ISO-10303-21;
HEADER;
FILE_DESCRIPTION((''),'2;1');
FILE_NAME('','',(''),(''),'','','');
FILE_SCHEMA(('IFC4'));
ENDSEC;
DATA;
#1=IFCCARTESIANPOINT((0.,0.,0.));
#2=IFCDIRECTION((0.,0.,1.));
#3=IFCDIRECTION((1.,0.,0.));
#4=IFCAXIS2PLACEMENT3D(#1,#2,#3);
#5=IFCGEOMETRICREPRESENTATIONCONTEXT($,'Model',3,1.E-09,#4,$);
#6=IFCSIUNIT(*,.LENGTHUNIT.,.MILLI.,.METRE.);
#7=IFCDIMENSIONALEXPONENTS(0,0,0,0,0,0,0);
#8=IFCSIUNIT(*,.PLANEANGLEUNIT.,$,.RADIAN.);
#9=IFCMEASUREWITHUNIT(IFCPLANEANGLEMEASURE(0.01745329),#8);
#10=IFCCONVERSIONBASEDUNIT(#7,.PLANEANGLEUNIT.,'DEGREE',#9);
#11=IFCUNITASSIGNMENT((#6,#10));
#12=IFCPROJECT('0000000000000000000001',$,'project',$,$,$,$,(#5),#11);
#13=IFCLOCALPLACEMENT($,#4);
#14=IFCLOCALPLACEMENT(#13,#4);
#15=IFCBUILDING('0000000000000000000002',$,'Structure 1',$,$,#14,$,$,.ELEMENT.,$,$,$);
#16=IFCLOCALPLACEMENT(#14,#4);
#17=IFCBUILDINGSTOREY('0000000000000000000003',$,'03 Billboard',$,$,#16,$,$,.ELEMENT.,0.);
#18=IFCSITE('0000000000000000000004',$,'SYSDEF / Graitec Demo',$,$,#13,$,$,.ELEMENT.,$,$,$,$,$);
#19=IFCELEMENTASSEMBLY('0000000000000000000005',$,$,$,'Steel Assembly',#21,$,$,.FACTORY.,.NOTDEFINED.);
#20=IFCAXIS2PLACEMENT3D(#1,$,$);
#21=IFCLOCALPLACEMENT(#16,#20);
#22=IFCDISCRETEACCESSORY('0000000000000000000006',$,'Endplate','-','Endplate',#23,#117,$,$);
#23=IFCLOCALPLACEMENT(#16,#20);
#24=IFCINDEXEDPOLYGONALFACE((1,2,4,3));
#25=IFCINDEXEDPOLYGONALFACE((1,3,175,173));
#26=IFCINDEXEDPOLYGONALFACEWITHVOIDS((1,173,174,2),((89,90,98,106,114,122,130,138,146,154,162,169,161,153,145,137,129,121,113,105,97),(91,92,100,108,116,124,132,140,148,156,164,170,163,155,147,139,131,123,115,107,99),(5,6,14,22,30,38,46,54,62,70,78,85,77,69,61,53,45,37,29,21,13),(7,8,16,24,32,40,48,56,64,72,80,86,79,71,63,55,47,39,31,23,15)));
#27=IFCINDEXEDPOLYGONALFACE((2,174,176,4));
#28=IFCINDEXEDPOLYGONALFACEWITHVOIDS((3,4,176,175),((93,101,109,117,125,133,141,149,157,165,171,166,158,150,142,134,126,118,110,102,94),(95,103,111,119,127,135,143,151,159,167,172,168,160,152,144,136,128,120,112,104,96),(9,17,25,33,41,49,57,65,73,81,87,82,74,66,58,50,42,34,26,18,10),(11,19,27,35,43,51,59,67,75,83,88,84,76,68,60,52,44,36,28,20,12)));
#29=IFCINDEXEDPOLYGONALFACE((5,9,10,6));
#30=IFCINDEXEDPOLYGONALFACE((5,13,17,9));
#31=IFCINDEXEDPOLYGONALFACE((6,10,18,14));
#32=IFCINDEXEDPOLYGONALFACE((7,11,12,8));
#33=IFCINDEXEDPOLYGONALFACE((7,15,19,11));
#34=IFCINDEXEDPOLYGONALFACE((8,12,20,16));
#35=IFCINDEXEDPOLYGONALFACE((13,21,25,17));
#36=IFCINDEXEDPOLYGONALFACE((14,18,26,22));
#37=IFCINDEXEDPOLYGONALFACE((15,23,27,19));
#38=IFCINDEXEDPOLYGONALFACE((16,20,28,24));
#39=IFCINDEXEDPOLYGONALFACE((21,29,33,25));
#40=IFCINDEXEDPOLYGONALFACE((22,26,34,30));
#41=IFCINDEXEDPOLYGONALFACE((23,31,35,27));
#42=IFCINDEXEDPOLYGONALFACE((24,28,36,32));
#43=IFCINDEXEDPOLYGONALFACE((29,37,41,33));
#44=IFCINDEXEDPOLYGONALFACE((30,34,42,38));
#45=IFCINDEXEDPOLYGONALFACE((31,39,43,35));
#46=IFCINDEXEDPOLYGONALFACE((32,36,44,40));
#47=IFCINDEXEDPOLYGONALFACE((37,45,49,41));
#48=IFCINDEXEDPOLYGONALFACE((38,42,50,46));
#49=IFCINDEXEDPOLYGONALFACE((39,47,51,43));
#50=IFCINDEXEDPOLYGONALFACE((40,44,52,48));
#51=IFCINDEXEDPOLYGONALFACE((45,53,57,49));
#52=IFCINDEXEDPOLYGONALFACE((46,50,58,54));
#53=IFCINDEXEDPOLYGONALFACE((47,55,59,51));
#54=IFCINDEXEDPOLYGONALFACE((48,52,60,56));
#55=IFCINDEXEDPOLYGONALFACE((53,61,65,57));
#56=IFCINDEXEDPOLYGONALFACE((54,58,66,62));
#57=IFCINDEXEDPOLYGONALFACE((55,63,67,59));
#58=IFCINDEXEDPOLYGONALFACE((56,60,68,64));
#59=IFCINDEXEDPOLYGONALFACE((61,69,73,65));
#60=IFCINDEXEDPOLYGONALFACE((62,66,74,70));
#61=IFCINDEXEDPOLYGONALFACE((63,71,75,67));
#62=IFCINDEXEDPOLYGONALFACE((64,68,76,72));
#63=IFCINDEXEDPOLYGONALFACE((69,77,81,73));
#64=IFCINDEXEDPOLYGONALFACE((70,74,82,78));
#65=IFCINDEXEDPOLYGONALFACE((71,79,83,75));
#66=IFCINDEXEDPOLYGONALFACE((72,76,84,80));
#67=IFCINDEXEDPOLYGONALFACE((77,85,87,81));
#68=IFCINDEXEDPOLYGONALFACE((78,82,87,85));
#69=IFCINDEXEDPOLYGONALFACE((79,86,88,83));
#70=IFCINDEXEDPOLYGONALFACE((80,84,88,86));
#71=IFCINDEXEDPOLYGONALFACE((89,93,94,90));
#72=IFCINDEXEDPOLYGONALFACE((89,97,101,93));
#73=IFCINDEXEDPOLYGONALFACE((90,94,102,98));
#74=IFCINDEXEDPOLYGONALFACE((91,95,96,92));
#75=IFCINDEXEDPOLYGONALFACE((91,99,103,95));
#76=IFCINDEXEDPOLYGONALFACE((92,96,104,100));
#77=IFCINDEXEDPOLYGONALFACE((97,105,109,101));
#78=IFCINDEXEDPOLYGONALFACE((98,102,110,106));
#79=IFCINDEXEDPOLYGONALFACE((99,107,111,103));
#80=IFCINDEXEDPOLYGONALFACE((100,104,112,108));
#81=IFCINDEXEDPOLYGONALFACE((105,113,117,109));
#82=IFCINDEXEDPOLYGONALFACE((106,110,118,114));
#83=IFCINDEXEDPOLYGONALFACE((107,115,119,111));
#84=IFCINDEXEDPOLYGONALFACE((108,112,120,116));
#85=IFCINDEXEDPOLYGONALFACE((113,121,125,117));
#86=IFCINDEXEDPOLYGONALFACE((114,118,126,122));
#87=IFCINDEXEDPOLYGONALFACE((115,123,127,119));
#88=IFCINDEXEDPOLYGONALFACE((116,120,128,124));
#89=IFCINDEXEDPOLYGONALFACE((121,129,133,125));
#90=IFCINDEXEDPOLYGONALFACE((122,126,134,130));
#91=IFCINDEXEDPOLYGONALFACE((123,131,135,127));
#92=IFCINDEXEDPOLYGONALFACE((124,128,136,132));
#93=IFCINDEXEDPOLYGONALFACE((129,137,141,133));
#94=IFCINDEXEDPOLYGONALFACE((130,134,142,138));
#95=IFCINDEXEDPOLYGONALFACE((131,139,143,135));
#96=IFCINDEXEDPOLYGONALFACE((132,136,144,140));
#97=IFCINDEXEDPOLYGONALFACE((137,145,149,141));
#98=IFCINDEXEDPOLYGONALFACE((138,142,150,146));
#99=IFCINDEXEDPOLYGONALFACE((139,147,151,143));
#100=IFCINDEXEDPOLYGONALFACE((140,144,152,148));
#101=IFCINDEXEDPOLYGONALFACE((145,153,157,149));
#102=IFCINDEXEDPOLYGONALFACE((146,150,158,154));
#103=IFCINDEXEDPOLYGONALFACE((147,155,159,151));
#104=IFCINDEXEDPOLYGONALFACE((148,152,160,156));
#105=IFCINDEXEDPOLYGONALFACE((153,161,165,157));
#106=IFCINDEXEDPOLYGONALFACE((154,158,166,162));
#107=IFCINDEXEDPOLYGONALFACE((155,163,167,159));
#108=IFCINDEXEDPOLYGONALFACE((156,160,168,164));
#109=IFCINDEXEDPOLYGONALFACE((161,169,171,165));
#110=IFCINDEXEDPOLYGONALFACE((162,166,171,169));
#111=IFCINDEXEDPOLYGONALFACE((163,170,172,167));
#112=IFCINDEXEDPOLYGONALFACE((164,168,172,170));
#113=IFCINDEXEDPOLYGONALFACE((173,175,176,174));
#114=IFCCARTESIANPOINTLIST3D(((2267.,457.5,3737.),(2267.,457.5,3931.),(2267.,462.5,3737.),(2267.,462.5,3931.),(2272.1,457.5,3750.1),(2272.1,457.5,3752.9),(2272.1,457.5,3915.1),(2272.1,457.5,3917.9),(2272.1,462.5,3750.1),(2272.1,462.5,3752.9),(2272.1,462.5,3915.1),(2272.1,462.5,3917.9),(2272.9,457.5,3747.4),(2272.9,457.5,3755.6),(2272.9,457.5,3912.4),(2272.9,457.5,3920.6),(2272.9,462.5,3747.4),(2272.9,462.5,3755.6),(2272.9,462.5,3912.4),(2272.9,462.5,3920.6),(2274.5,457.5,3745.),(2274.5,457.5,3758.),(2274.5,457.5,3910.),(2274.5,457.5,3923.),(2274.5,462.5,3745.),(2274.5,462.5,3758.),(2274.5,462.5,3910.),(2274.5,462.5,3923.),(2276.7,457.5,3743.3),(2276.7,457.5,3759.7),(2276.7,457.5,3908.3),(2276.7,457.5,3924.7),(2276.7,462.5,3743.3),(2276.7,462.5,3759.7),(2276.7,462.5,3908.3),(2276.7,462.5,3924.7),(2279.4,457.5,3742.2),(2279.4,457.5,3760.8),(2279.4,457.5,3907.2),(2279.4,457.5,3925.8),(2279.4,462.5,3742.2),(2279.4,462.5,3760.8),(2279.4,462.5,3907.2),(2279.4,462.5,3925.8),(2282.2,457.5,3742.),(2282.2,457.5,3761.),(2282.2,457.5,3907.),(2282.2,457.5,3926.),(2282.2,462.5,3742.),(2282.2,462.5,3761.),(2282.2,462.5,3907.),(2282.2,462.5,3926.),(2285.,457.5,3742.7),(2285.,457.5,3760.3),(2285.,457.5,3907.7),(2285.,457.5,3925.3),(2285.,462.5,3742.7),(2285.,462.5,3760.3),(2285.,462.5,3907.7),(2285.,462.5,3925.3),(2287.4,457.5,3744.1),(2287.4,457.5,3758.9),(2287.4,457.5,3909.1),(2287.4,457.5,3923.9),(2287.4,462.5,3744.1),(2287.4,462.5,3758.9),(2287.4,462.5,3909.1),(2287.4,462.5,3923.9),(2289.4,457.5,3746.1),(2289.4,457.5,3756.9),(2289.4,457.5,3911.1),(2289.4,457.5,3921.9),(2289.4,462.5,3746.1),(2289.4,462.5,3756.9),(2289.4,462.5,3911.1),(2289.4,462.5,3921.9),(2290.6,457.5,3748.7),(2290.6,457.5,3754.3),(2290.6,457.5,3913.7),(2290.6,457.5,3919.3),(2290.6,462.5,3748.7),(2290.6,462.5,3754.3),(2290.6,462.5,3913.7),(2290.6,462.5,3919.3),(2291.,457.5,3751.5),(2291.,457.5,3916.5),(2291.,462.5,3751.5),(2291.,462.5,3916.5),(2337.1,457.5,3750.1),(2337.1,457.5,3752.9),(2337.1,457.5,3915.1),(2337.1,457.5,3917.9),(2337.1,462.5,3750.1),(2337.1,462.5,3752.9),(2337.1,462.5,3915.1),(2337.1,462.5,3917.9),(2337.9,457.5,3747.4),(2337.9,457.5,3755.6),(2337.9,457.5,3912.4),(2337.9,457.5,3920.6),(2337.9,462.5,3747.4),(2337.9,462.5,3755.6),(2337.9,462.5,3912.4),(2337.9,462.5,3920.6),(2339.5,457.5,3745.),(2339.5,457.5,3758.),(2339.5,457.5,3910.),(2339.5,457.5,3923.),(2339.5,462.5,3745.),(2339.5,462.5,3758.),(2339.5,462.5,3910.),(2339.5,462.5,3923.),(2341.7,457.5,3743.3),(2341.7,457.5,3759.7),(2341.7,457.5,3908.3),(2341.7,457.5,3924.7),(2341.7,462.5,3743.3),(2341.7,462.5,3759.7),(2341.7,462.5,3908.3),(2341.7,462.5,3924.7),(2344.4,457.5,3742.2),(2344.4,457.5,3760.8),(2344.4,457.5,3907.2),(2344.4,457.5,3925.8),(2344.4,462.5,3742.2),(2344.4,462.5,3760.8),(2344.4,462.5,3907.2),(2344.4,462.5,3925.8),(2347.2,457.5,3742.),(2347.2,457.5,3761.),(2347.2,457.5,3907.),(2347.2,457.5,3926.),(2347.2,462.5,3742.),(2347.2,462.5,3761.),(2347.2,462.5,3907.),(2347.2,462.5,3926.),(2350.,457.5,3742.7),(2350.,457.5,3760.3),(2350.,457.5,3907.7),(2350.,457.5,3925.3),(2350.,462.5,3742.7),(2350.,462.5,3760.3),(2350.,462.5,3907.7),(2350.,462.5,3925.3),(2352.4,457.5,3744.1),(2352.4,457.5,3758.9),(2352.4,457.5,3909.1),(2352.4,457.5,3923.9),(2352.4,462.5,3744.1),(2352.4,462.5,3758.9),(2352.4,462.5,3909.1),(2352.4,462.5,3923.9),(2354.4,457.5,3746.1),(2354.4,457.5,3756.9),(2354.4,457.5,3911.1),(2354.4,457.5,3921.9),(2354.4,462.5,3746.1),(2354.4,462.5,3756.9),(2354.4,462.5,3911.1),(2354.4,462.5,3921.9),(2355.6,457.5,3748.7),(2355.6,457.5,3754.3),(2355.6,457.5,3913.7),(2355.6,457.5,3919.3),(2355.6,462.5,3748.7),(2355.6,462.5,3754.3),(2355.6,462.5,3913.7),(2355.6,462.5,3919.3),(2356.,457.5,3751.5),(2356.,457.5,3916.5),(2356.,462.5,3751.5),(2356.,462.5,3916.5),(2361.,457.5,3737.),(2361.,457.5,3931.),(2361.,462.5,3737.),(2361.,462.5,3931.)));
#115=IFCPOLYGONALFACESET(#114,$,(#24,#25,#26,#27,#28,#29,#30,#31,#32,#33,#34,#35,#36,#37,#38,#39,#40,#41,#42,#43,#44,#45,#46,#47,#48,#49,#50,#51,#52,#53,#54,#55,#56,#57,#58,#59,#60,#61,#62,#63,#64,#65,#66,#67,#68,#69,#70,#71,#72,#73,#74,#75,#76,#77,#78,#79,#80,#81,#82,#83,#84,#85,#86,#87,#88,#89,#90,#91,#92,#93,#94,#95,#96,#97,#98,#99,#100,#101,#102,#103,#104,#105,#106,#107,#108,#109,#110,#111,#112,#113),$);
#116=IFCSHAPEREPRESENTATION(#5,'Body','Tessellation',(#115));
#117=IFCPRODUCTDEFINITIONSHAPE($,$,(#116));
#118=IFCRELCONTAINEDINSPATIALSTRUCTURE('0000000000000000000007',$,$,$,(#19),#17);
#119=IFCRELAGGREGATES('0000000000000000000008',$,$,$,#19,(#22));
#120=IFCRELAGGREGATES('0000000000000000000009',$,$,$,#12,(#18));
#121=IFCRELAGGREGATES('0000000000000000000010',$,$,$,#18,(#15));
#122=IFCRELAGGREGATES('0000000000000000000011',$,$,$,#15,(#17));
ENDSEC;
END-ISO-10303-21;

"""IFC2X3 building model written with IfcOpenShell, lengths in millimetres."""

from ifc_helpers import new_model, entity, si_unit, converted_unit, frame, frame_2d, origin, origin_with_axes, place, context, project, spatial, polyline, circle, outline, extrude, element, aggregate, save


model = new_model("IFC2X3")

# Units and contexts
model_context = context("Model", 3, precision=1e-09, world=origin_with_axes())
ifc_project = project(units=[si_unit("LENGTHUNIT", "METRE", prefix="MILLI"), converted_unit("PLANEANGLEUNIT", "DEGREE", entity("IfcPlaneAngleMeasure", 0.01745329), si_unit("PLANEANGLEUNIT", "RADIAN"), dimensions=[0, 0, 0, 0, 0, 0, 0])], contexts=[model_context])

# Site, building, storey
site_placement = place(None, origin_with_axes())
site = spatial("IfcSite", under=ifc_project, at=site_placement, Name="SYSDEF / Graitec Demo", CompositionType="ELEMENT")
building_placement = place(site_placement, origin_with_axes())
building = spatial("IfcBuilding", under=site, at=building_placement, Name="Structure 1", CompositionType="ELEMENT")
storey_placement = place(building_placement, origin_with_axes())
storey = spatial("IfcBuildingStorey", under=building, at=storey_placement, Name="03 Billboard", CompositionType="ELEMENT", Elevation=0.0)

# Element assembly, discrete accessory, openings
assembly_1_placement = place(None, frame((-4406.3, 0.0, 3558.0), z_axis=(-1.0, 0.0, 0.0), x_axis=(0.0, -1.0, 0.0)))
assembly_1 = element("IfcElementAssembly", 1, at=assembly_1_placement, inside=storey, ObjectType="Steel Assembly", AssemblyPlace="FACTORY", PredefinedType="NOTDEFINED")
discrete_accessory_1_placement = place(assembly_1_placement, frame((-457.5, 373.0, -6673.3), z_axis=(-1.0, 0.0, 0.0), x_axis=(0.0, 0.0, -1.0)))
discrete_accessory_1 = element("IfcDiscreteAccessory", 2, at=discrete_accessory_1_placement, Name="Endplate", Description="-", ObjectType="Endplate", context=model_context, shape_type="SweptSolid", body=[
    extrude(outline(polyline([(0.0, 0.0), (94.0, 0.0), (94.0, 194.0), (0.0, 194.0), (0.0, 0.0)])), origin_with_axes(), (0.0, 0.0, 1.0), 5.0),
])
opening_1_placement = place(discrete_accessory_1_placement, frame((47.0, 97.0, 5.5), z_axis=(0.0, 0.0, -1.0), x_axis=(1.0, 0.0, 0.0)))
element("IfcOpeningElement", 3, at=opening_1_placement, cuts=discrete_accessory_1, ObjectType="Opening", context=model_context, shape_type="SweptSolid", body=[
    extrude(circle(Radius=9.5, at=frame_2d((32.5, 82.5), x_axis=(1.0, 0.0))), origin(), (0.0, 0.0, 1.0), 6.0),
])
opening_2_placement = place(discrete_accessory_1_placement, frame((47.0, 97.0, 5.5), z_axis=(0.0, 0.0, -1.0), x_axis=(1.0, 0.0, 0.0)))
element("IfcOpeningElement", 4, at=opening_2_placement, cuts=discrete_accessory_1, ObjectType="Opening", context=model_context, shape_type="SweptSolid", body=[
    extrude(circle(Radius=9.5, at=frame_2d((-32.5, 82.5), x_axis=(1.0, 0.0))), origin(), (0.0, 0.0, 1.0), 6.0),
])
opening_3_placement = place(discrete_accessory_1_placement, frame((47.0, 97.0, 5.5), z_axis=(0.0, 0.0, -1.0), x_axis=(1.0, 0.0, 0.0)))
element("IfcOpeningElement", 5, at=opening_3_placement, cuts=discrete_accessory_1, ObjectType="Opening", context=model_context, shape_type="SweptSolid", body=[
    extrude(circle(Radius=9.5, at=frame_2d((32.5, -82.5), x_axis=(1.0, 0.0))), origin(), (0.0, 0.0, 1.0), 6.0),
])
opening_4_placement = place(discrete_accessory_1_placement, frame((47.0, 97.0, 5.5), z_axis=(0.0, 0.0, -1.0), x_axis=(1.0, 0.0, 0.0)))
element("IfcOpeningElement", 6, at=opening_4_placement, cuts=discrete_accessory_1, ObjectType="Opening", context=model_context, shape_type="SweptSolid", body=[
    extrude(circle(Radius=9.5, at=frame_2d((-32.5, -82.5), x_axis=(1.0, 0.0))), origin(), (0.0, 0.0, 1.0), 6.0),
])

aggregate(assembly_1, [discrete_accessory_1])

save(model, "model.ifc")
